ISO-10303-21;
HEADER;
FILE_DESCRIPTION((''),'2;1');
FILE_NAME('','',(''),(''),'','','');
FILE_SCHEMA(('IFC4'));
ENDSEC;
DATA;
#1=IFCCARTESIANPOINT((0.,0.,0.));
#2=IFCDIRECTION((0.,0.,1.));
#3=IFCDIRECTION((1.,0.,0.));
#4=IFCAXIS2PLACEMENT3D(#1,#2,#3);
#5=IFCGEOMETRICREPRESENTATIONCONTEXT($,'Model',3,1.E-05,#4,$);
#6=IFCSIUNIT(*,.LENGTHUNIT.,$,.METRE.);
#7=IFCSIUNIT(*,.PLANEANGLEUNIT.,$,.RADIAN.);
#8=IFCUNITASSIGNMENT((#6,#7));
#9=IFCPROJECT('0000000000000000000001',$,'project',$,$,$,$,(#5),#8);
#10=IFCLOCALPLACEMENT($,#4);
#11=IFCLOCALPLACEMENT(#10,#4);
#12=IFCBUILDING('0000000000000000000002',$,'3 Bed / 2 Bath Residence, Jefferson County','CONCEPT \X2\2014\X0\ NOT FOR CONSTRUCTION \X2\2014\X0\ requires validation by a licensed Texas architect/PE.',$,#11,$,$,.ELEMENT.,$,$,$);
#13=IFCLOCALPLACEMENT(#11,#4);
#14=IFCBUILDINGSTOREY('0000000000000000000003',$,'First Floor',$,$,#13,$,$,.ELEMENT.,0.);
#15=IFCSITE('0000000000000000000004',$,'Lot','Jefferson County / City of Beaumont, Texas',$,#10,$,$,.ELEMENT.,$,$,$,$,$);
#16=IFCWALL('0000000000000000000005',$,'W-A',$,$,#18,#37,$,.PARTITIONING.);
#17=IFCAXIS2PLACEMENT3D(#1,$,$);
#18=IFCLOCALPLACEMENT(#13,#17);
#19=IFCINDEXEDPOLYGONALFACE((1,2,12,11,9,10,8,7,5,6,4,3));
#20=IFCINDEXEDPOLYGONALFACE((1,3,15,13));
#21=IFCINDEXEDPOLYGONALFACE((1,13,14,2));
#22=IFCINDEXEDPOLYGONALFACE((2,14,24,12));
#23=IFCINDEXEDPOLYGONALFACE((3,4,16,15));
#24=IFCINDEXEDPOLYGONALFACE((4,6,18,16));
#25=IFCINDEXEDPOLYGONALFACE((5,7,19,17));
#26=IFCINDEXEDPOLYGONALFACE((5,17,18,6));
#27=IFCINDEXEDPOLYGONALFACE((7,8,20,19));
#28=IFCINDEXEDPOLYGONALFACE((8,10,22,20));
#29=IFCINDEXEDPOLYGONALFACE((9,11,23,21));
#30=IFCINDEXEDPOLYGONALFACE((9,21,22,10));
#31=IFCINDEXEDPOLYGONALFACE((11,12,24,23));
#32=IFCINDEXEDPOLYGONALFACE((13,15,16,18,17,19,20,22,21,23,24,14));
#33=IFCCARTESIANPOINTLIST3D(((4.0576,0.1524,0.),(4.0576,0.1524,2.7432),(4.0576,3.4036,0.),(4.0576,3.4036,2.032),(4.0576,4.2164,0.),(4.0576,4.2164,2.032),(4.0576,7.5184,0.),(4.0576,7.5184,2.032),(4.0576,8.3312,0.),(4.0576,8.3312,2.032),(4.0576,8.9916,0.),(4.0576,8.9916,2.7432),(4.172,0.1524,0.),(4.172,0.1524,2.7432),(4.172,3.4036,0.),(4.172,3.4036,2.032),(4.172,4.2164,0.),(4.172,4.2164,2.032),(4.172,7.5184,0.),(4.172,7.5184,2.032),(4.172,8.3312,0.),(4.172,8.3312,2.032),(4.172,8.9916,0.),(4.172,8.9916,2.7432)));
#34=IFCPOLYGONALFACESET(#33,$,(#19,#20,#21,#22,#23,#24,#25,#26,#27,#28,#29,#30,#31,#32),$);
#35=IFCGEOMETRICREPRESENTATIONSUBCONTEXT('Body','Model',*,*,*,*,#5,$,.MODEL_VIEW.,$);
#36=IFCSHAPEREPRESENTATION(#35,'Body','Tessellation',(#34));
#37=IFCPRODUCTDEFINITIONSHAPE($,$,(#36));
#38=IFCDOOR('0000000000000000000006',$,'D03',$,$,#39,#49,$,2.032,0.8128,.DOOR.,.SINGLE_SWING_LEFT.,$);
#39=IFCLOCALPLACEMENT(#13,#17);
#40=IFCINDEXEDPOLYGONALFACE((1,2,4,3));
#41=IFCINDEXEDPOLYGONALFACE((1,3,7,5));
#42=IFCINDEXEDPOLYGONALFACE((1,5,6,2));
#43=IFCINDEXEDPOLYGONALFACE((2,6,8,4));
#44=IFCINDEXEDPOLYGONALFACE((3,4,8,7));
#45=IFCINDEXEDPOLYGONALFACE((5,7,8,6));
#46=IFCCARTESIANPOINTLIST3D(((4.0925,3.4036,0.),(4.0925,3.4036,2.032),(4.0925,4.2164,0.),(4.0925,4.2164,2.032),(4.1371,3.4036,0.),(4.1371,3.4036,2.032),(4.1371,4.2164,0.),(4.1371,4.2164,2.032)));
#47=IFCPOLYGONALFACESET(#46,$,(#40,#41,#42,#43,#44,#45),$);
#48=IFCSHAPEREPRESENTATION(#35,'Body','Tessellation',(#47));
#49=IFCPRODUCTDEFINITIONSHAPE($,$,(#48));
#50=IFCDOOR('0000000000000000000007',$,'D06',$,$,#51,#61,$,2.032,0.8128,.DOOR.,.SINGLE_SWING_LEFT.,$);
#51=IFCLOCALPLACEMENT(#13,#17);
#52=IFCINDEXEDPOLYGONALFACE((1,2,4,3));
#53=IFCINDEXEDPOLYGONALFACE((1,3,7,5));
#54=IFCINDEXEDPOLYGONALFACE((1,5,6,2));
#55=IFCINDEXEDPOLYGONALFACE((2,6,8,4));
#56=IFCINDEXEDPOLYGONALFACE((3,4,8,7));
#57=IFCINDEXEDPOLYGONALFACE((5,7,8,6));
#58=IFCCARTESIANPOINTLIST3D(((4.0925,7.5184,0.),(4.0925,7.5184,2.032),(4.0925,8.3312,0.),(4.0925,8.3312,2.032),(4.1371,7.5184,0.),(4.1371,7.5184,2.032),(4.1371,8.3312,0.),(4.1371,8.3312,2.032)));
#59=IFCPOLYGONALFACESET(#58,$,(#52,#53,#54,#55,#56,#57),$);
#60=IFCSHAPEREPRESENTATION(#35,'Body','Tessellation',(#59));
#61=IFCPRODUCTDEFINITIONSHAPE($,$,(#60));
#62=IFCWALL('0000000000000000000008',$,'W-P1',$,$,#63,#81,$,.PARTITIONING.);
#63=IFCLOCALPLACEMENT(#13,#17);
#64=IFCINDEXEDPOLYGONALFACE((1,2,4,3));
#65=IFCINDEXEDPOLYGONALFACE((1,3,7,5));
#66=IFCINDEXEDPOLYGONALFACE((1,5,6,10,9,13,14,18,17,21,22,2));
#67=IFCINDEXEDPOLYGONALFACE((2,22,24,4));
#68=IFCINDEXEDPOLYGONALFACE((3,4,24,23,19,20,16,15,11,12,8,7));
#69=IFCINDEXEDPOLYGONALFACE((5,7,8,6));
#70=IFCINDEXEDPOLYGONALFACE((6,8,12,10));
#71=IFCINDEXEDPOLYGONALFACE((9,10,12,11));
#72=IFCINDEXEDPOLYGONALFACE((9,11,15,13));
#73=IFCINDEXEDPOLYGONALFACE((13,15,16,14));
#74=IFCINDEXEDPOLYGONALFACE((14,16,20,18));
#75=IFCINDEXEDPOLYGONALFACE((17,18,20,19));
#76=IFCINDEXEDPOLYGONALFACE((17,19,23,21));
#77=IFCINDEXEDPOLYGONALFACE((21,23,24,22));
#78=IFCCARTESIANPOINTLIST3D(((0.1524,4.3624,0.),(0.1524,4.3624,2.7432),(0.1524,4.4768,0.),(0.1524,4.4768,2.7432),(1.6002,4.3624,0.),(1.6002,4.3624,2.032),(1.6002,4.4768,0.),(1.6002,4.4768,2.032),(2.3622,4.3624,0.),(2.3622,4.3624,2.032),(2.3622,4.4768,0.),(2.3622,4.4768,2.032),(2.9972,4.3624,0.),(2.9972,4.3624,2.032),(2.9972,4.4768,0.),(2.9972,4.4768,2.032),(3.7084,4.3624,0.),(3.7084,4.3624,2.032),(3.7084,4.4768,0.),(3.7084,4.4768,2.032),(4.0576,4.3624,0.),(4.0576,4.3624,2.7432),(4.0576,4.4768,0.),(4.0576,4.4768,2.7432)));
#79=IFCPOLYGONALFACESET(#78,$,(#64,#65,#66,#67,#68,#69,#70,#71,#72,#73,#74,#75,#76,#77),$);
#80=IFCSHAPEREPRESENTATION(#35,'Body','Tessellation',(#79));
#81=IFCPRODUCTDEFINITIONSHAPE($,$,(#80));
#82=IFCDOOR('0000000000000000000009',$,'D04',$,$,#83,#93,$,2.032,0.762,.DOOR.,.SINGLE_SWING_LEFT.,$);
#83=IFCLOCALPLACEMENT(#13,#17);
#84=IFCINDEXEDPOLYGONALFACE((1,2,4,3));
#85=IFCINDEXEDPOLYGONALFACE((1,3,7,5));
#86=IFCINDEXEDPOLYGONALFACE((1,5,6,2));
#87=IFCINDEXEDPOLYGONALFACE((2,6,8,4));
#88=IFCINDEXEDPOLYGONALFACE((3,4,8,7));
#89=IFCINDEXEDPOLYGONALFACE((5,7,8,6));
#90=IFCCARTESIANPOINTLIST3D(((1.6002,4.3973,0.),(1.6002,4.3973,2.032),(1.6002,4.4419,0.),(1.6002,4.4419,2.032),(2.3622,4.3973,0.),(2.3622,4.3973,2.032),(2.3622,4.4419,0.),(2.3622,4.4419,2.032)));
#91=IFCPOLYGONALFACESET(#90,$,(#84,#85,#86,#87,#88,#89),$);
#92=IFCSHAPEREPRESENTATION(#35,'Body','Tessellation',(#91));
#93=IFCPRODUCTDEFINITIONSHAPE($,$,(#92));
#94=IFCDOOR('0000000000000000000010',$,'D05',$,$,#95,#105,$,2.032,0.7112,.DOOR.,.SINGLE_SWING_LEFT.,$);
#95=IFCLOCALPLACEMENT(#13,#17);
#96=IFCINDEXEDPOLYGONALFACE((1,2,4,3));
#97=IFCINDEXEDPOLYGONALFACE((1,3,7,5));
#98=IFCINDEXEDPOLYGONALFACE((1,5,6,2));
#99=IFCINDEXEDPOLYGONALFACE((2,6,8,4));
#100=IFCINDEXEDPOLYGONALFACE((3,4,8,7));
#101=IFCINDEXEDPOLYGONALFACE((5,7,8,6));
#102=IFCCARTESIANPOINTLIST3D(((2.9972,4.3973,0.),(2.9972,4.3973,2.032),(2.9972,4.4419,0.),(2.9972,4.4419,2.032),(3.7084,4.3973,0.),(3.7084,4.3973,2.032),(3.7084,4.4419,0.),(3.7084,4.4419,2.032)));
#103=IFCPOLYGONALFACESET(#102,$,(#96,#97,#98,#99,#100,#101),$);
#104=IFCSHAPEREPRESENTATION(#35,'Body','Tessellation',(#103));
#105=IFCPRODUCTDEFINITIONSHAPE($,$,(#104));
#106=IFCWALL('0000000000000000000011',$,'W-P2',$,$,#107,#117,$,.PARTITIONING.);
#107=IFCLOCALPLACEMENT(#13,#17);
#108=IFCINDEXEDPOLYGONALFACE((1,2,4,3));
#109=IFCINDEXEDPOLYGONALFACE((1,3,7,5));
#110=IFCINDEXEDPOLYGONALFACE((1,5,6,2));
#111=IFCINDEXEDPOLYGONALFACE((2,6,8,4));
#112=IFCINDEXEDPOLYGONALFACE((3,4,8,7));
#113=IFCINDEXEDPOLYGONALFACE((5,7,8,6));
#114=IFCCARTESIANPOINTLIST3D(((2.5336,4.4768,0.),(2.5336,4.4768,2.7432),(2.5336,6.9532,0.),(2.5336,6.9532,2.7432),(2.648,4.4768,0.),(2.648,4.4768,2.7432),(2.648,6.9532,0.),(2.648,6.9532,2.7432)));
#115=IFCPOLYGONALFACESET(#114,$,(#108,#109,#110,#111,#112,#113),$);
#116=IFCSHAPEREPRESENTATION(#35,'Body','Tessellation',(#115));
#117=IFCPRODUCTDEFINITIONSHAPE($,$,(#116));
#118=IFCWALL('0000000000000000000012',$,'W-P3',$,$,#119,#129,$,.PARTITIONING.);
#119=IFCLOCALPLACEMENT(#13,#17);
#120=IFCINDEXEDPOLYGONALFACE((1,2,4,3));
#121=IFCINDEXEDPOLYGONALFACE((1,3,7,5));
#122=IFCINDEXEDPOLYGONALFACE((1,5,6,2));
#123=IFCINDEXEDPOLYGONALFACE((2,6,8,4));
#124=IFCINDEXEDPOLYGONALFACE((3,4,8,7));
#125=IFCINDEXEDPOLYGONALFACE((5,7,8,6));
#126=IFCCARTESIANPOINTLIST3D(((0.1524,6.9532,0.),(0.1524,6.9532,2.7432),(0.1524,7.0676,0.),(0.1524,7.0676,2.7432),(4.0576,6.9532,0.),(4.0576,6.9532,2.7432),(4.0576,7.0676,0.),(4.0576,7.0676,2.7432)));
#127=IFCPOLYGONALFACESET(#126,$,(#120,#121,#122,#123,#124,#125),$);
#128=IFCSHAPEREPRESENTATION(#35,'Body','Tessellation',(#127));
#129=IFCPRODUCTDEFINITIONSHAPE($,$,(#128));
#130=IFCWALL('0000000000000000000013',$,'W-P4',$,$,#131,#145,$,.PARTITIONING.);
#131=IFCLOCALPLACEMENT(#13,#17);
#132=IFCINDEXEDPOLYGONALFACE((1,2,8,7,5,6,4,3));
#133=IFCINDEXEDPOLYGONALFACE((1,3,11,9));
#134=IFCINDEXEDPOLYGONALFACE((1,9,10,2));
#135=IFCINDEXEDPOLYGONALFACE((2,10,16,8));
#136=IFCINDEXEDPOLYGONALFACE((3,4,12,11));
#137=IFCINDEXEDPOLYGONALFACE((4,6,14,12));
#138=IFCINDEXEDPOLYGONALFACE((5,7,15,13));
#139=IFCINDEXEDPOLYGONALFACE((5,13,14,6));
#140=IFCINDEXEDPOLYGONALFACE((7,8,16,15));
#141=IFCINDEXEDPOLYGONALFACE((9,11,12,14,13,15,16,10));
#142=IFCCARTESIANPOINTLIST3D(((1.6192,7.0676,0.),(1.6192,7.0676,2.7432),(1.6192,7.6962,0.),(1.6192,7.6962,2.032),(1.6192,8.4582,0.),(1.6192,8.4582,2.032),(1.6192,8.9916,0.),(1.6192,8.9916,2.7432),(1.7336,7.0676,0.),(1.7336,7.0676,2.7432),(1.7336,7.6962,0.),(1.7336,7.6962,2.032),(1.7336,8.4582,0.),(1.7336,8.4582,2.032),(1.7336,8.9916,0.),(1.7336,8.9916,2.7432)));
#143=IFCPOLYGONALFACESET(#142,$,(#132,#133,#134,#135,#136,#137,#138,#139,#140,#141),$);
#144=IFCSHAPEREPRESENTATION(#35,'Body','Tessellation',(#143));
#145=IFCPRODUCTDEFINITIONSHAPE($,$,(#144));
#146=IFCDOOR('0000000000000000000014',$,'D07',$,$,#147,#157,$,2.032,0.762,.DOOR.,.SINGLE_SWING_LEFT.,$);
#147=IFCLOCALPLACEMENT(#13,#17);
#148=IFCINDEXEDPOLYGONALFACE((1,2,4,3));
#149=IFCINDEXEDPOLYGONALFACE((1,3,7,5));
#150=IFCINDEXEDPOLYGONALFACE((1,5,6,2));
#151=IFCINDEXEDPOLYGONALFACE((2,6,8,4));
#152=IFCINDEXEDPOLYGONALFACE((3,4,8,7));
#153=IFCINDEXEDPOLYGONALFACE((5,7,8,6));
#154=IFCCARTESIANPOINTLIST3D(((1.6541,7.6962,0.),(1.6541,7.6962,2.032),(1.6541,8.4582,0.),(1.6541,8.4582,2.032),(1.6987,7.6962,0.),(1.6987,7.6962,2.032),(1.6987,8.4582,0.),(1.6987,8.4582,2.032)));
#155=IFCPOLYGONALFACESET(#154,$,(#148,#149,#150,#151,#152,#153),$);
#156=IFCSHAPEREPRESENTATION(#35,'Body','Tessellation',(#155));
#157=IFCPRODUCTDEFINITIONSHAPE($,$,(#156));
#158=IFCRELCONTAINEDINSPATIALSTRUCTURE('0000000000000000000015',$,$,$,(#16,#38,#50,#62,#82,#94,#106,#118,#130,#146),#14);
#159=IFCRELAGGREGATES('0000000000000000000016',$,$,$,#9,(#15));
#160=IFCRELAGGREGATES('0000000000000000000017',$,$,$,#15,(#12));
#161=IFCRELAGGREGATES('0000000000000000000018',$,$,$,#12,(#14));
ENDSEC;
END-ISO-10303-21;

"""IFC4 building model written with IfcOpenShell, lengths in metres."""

from ifc_helpers import new_model, si_unit, frame, frame_2d, origin_with_axes, place, context, subcontext, project, spatial, rectangle, extrude, element, fill, save


model = new_model("IFC4")

# Units and contexts
model_context = context("Model", 3, precision=1e-05, world=origin_with_axes())
body_context = subcontext(model_context, "Body", "Model", "MODEL_VIEW")
ifc_project = project(units=[si_unit("LENGTHUNIT", "METRE"), si_unit("PLANEANGLEUNIT", "RADIAN")], contexts=[model_context])

# Site, building, storey
site_placement = place(None, origin_with_axes())
site = spatial("IfcSite", under=ifc_project, at=site_placement, Name="Lot", Description="Jefferson County / City of Beaumont, Texas", CompositionType="ELEMENT")
building_placement = place(site_placement, origin_with_axes())
building = spatial("IfcBuilding", under=site, at=building_placement, Name="3 Bed / 2 Bath Residence, Jefferson County", Description="CONCEPT — NOT FOR CONSTRUCTION — requires validation by a licensed Texas architect/PE.", CompositionType="ELEMENT")
storey_placement = place(building_placement, origin_with_axes())
storey = spatial("IfcBuildingStorey", under=building, at=storey_placement, Name="First Floor", CompositionType="ELEMENT", Elevation=0.0)

# Walls, openings, doors
wall_1_placement = place(storey_placement, frame((4.1148, 0.1524, 0.0), z_axis=(0.0, 0.0, 1.0), x_axis=(0.0, 1.0, 0.0)))
wall_1 = element("IfcWall", 1, at=wall_1_placement, inside=storey, Name="W-A", PredefinedType="PARTITIONING", context=body_context, shape_type="SweptSolid", body=[
    extrude(rectangle(XDim=8.8392, YDim=0.1143, at=frame_2d((4.4196, 0.0), x_axis=(1.0, 0.0))), origin_with_axes(), (0.0, 0.0, 1.0), 2.7432),
])
opening_1_placement = place(wall_1_placement, frame((3.2512, 0.0, 0.0), z_axis=(0.0, 0.0, 1.0), x_axis=(1.0, 0.0, 0.0)))
opening_1 = element("IfcOpeningElement", 2, at=opening_1_placement, cuts=wall_1, PredefinedType="OPENING", context=body_context, shape_type="SweptSolid", body=[
    extrude(rectangle(XDim=0.8128, YDim=0.1448, at=frame_2d((0.4064, 0.0), x_axis=(1.0, 0.0))), origin_with_axes(), (0.0, 0.0, 1.0), 2.032),
])
opening_2_placement = place(wall_1_placement, frame((7.366, 0.0, 0.0), z_axis=(0.0, 0.0, 1.0), x_axis=(1.0, 0.0, 0.0)))
opening_2 = element("IfcOpeningElement", 3, at=opening_2_placement, cuts=wall_1, PredefinedType="OPENING", context=body_context, shape_type="SweptSolid", body=[
    extrude(rectangle(XDim=0.8128, YDim=0.1448, at=frame_2d((0.4064, 0.0), x_axis=(1.0, 0.0))), origin_with_axes(), (0.0, 0.0, 1.0), 2.032),
])
door_1_placement = place(opening_1_placement, origin_with_axes())
door_1 = element("IfcDoor", 4, at=door_1_placement, inside=storey, Name="D03", OperationType="SINGLE_SWING_LEFT", OverallHeight=2.032, OverallWidth=0.8128, PredefinedType="DOOR", context=body_context, shape_type="SweptSolid", body=[
    extrude(rectangle(XDim=0.8128, YDim=0.0445, at=frame_2d((0.4064, 0.0), x_axis=(1.0, 0.0))), origin_with_axes(), (0.0, 0.0, 1.0), 2.032),
])
fill(opening_1, door_1)
door_2_placement = place(opening_2_placement, origin_with_axes())
door_2 = element("IfcDoor", 5, at=door_2_placement, inside=storey, Name="D06", OperationType="SINGLE_SWING_LEFT", OverallHeight=2.032, OverallWidth=0.8128, PredefinedType="DOOR", context=body_context, shape_type="SweptSolid", body=[
    extrude(rectangle(XDim=0.8128, YDim=0.0445, at=frame_2d((0.4064, 0.0), x_axis=(1.0, 0.0))), origin_with_axes(), (0.0, 0.0, 1.0), 2.032),
])
fill(opening_2, door_2)
wall_2_placement = place(storey_placement, frame((0.1524, 4.4196, 0.0), z_axis=(0.0, 0.0, 1.0), x_axis=(1.0, 0.0, 0.0)))
wall_2 = element("IfcWall", 6, at=wall_2_placement, inside=storey, Name="W-P1", PredefinedType="PARTITIONING", context=body_context, shape_type="SweptSolid", body=[
    extrude(rectangle(XDim=3.9053, YDim=0.1143, at=frame_2d((1.9526, 0.0), x_axis=(1.0, 0.0))), origin_with_axes(), (0.0, 0.0, 1.0), 2.7432),
])
opening_3_placement = place(wall_2_placement, frame((1.4478, 0.0, 0.0), z_axis=(0.0, 0.0, 1.0), x_axis=(1.0, 0.0, 0.0)))
opening_3 = element("IfcOpeningElement", 7, at=opening_3_placement, cuts=wall_2, PredefinedType="OPENING", context=body_context, shape_type="SweptSolid", body=[
    extrude(rectangle(XDim=0.762, YDim=0.1448, at=frame_2d((0.381, 0.0), x_axis=(1.0, 0.0))), origin_with_axes(), (0.0, 0.0, 1.0), 2.032),
])
opening_4_placement = place(wall_2_placement, frame((2.8448, 0.0, 0.0), z_axis=(0.0, 0.0, 1.0), x_axis=(1.0, 0.0, 0.0)))
opening_4 = element("IfcOpeningElement", 8, at=opening_4_placement, cuts=wall_2, PredefinedType="OPENING", context=body_context, shape_type="SweptSolid", body=[
    extrude(rectangle(XDim=0.7112, YDim=0.1448, at=frame_2d((0.3556, 0.0), x_axis=(1.0, 0.0))), origin_with_axes(), (0.0, 0.0, 1.0), 2.032),
])
door_3_placement = place(opening_3_placement, origin_with_axes())
door_3 = element("IfcDoor", 9, at=door_3_placement, inside=storey, Name="D04", OperationType="SINGLE_SWING_LEFT", OverallHeight=2.032, OverallWidth=0.762, PredefinedType="DOOR", context=body_context, shape_type="SweptSolid", body=[
    extrude(rectangle(XDim=0.762, YDim=0.0445, at=frame_2d((0.381, 0.0), x_axis=(1.0, 0.0))), origin_with_axes(), (0.0, 0.0, 1.0), 2.032),
])
fill(opening_3, door_3)
door_4_placement = place(opening_4_placement, origin_with_axes())
door_4 = element("IfcDoor", 10, at=door_4_placement, inside=storey, Name="D05", OperationType="SINGLE_SWING_LEFT", OverallHeight=2.032, OverallWidth=0.7112, PredefinedType="DOOR", context=body_context, shape_type="SweptSolid", body=[
    extrude(rectangle(XDim=0.7112, YDim=0.0445, at=frame_2d((0.3556, 0.0), x_axis=(1.0, 0.0))), origin_with_axes(), (0.0, 0.0, 1.0), 2.032),
])
fill(opening_4, door_4)

# Walls
wall_3_placement = place(storey_placement, frame((2.5908, 4.4768, 0.0), z_axis=(0.0, 0.0, 1.0), x_axis=(0.0, 1.0, 0.0)))
element("IfcWall", 11, at=wall_3_placement, inside=storey, Name="W-P2", PredefinedType="PARTITIONING", context=body_context, shape_type="SweptSolid", body=[
    extrude(rectangle(XDim=2.4765, YDim=0.1143, at=frame_2d((1.2383, 0.0), x_axis=(1.0, 0.0))), origin_with_axes(), (0.0, 0.0, 1.0), 2.7432),
])
wall_4_placement = place(storey_placement, frame((0.1524, 7.0104, 0.0), z_axis=(0.0, 0.0, 1.0), x_axis=(1.0, 0.0, 0.0)))
element("IfcWall", 12, at=wall_4_placement, inside=storey, Name="W-P3", PredefinedType="PARTITIONING", context=body_context, shape_type="SweptSolid", body=[
    extrude(rectangle(XDim=3.9053, YDim=0.1143, at=frame_2d((1.9526, 0.0), x_axis=(1.0, 0.0))), origin_with_axes(), (0.0, 0.0, 1.0), 2.7432),
])

# Wall, opening, door
wall_5_placement = place(storey_placement, frame((1.6764, 7.0676, 0.0), z_axis=(0.0, 0.0, 1.0), x_axis=(0.0, 1.0, 0.0)))
wall_5 = element("IfcWall", 13, at=wall_5_placement, inside=storey, Name="W-P4", PredefinedType="PARTITIONING", context=body_context, shape_type="SweptSolid", body=[
    extrude(rectangle(XDim=1.9241, YDim=0.1143, at=frame_2d((0.962, 0.0), x_axis=(1.0, 0.0))), origin_with_axes(), (0.0, 0.0, 1.0), 2.7432),
])
opening_5_placement = place(wall_5_placement, frame((0.6287, 0.0, 0.0), z_axis=(0.0, 0.0, 1.0), x_axis=(1.0, 0.0, 0.0)))
opening_5 = element("IfcOpeningElement", 14, at=opening_5_placement, cuts=wall_5, PredefinedType="OPENING", context=body_context, shape_type="SweptSolid", body=[
    extrude(rectangle(XDim=0.762, YDim=0.1448, at=frame_2d((0.381, 0.0), x_axis=(1.0, 0.0))), origin_with_axes(), (0.0, 0.0, 1.0), 2.032),
])
door_5_placement = place(opening_5_placement, origin_with_axes())
door_5 = element("IfcDoor", 15, at=door_5_placement, inside=storey, Name="D07", OperationType="SINGLE_SWING_LEFT", OverallHeight=2.032, OverallWidth=0.762, PredefinedType="DOOR", context=body_context, shape_type="SweptSolid", body=[
    extrude(rectangle(XDim=0.762, YDim=0.0445, at=frame_2d((0.381, 0.0), x_axis=(1.0, 0.0))), origin_with_axes(), (0.0, 0.0, 1.0), 2.032),
])
fill(opening_5, door_5)

save(model, "model.ifc")
